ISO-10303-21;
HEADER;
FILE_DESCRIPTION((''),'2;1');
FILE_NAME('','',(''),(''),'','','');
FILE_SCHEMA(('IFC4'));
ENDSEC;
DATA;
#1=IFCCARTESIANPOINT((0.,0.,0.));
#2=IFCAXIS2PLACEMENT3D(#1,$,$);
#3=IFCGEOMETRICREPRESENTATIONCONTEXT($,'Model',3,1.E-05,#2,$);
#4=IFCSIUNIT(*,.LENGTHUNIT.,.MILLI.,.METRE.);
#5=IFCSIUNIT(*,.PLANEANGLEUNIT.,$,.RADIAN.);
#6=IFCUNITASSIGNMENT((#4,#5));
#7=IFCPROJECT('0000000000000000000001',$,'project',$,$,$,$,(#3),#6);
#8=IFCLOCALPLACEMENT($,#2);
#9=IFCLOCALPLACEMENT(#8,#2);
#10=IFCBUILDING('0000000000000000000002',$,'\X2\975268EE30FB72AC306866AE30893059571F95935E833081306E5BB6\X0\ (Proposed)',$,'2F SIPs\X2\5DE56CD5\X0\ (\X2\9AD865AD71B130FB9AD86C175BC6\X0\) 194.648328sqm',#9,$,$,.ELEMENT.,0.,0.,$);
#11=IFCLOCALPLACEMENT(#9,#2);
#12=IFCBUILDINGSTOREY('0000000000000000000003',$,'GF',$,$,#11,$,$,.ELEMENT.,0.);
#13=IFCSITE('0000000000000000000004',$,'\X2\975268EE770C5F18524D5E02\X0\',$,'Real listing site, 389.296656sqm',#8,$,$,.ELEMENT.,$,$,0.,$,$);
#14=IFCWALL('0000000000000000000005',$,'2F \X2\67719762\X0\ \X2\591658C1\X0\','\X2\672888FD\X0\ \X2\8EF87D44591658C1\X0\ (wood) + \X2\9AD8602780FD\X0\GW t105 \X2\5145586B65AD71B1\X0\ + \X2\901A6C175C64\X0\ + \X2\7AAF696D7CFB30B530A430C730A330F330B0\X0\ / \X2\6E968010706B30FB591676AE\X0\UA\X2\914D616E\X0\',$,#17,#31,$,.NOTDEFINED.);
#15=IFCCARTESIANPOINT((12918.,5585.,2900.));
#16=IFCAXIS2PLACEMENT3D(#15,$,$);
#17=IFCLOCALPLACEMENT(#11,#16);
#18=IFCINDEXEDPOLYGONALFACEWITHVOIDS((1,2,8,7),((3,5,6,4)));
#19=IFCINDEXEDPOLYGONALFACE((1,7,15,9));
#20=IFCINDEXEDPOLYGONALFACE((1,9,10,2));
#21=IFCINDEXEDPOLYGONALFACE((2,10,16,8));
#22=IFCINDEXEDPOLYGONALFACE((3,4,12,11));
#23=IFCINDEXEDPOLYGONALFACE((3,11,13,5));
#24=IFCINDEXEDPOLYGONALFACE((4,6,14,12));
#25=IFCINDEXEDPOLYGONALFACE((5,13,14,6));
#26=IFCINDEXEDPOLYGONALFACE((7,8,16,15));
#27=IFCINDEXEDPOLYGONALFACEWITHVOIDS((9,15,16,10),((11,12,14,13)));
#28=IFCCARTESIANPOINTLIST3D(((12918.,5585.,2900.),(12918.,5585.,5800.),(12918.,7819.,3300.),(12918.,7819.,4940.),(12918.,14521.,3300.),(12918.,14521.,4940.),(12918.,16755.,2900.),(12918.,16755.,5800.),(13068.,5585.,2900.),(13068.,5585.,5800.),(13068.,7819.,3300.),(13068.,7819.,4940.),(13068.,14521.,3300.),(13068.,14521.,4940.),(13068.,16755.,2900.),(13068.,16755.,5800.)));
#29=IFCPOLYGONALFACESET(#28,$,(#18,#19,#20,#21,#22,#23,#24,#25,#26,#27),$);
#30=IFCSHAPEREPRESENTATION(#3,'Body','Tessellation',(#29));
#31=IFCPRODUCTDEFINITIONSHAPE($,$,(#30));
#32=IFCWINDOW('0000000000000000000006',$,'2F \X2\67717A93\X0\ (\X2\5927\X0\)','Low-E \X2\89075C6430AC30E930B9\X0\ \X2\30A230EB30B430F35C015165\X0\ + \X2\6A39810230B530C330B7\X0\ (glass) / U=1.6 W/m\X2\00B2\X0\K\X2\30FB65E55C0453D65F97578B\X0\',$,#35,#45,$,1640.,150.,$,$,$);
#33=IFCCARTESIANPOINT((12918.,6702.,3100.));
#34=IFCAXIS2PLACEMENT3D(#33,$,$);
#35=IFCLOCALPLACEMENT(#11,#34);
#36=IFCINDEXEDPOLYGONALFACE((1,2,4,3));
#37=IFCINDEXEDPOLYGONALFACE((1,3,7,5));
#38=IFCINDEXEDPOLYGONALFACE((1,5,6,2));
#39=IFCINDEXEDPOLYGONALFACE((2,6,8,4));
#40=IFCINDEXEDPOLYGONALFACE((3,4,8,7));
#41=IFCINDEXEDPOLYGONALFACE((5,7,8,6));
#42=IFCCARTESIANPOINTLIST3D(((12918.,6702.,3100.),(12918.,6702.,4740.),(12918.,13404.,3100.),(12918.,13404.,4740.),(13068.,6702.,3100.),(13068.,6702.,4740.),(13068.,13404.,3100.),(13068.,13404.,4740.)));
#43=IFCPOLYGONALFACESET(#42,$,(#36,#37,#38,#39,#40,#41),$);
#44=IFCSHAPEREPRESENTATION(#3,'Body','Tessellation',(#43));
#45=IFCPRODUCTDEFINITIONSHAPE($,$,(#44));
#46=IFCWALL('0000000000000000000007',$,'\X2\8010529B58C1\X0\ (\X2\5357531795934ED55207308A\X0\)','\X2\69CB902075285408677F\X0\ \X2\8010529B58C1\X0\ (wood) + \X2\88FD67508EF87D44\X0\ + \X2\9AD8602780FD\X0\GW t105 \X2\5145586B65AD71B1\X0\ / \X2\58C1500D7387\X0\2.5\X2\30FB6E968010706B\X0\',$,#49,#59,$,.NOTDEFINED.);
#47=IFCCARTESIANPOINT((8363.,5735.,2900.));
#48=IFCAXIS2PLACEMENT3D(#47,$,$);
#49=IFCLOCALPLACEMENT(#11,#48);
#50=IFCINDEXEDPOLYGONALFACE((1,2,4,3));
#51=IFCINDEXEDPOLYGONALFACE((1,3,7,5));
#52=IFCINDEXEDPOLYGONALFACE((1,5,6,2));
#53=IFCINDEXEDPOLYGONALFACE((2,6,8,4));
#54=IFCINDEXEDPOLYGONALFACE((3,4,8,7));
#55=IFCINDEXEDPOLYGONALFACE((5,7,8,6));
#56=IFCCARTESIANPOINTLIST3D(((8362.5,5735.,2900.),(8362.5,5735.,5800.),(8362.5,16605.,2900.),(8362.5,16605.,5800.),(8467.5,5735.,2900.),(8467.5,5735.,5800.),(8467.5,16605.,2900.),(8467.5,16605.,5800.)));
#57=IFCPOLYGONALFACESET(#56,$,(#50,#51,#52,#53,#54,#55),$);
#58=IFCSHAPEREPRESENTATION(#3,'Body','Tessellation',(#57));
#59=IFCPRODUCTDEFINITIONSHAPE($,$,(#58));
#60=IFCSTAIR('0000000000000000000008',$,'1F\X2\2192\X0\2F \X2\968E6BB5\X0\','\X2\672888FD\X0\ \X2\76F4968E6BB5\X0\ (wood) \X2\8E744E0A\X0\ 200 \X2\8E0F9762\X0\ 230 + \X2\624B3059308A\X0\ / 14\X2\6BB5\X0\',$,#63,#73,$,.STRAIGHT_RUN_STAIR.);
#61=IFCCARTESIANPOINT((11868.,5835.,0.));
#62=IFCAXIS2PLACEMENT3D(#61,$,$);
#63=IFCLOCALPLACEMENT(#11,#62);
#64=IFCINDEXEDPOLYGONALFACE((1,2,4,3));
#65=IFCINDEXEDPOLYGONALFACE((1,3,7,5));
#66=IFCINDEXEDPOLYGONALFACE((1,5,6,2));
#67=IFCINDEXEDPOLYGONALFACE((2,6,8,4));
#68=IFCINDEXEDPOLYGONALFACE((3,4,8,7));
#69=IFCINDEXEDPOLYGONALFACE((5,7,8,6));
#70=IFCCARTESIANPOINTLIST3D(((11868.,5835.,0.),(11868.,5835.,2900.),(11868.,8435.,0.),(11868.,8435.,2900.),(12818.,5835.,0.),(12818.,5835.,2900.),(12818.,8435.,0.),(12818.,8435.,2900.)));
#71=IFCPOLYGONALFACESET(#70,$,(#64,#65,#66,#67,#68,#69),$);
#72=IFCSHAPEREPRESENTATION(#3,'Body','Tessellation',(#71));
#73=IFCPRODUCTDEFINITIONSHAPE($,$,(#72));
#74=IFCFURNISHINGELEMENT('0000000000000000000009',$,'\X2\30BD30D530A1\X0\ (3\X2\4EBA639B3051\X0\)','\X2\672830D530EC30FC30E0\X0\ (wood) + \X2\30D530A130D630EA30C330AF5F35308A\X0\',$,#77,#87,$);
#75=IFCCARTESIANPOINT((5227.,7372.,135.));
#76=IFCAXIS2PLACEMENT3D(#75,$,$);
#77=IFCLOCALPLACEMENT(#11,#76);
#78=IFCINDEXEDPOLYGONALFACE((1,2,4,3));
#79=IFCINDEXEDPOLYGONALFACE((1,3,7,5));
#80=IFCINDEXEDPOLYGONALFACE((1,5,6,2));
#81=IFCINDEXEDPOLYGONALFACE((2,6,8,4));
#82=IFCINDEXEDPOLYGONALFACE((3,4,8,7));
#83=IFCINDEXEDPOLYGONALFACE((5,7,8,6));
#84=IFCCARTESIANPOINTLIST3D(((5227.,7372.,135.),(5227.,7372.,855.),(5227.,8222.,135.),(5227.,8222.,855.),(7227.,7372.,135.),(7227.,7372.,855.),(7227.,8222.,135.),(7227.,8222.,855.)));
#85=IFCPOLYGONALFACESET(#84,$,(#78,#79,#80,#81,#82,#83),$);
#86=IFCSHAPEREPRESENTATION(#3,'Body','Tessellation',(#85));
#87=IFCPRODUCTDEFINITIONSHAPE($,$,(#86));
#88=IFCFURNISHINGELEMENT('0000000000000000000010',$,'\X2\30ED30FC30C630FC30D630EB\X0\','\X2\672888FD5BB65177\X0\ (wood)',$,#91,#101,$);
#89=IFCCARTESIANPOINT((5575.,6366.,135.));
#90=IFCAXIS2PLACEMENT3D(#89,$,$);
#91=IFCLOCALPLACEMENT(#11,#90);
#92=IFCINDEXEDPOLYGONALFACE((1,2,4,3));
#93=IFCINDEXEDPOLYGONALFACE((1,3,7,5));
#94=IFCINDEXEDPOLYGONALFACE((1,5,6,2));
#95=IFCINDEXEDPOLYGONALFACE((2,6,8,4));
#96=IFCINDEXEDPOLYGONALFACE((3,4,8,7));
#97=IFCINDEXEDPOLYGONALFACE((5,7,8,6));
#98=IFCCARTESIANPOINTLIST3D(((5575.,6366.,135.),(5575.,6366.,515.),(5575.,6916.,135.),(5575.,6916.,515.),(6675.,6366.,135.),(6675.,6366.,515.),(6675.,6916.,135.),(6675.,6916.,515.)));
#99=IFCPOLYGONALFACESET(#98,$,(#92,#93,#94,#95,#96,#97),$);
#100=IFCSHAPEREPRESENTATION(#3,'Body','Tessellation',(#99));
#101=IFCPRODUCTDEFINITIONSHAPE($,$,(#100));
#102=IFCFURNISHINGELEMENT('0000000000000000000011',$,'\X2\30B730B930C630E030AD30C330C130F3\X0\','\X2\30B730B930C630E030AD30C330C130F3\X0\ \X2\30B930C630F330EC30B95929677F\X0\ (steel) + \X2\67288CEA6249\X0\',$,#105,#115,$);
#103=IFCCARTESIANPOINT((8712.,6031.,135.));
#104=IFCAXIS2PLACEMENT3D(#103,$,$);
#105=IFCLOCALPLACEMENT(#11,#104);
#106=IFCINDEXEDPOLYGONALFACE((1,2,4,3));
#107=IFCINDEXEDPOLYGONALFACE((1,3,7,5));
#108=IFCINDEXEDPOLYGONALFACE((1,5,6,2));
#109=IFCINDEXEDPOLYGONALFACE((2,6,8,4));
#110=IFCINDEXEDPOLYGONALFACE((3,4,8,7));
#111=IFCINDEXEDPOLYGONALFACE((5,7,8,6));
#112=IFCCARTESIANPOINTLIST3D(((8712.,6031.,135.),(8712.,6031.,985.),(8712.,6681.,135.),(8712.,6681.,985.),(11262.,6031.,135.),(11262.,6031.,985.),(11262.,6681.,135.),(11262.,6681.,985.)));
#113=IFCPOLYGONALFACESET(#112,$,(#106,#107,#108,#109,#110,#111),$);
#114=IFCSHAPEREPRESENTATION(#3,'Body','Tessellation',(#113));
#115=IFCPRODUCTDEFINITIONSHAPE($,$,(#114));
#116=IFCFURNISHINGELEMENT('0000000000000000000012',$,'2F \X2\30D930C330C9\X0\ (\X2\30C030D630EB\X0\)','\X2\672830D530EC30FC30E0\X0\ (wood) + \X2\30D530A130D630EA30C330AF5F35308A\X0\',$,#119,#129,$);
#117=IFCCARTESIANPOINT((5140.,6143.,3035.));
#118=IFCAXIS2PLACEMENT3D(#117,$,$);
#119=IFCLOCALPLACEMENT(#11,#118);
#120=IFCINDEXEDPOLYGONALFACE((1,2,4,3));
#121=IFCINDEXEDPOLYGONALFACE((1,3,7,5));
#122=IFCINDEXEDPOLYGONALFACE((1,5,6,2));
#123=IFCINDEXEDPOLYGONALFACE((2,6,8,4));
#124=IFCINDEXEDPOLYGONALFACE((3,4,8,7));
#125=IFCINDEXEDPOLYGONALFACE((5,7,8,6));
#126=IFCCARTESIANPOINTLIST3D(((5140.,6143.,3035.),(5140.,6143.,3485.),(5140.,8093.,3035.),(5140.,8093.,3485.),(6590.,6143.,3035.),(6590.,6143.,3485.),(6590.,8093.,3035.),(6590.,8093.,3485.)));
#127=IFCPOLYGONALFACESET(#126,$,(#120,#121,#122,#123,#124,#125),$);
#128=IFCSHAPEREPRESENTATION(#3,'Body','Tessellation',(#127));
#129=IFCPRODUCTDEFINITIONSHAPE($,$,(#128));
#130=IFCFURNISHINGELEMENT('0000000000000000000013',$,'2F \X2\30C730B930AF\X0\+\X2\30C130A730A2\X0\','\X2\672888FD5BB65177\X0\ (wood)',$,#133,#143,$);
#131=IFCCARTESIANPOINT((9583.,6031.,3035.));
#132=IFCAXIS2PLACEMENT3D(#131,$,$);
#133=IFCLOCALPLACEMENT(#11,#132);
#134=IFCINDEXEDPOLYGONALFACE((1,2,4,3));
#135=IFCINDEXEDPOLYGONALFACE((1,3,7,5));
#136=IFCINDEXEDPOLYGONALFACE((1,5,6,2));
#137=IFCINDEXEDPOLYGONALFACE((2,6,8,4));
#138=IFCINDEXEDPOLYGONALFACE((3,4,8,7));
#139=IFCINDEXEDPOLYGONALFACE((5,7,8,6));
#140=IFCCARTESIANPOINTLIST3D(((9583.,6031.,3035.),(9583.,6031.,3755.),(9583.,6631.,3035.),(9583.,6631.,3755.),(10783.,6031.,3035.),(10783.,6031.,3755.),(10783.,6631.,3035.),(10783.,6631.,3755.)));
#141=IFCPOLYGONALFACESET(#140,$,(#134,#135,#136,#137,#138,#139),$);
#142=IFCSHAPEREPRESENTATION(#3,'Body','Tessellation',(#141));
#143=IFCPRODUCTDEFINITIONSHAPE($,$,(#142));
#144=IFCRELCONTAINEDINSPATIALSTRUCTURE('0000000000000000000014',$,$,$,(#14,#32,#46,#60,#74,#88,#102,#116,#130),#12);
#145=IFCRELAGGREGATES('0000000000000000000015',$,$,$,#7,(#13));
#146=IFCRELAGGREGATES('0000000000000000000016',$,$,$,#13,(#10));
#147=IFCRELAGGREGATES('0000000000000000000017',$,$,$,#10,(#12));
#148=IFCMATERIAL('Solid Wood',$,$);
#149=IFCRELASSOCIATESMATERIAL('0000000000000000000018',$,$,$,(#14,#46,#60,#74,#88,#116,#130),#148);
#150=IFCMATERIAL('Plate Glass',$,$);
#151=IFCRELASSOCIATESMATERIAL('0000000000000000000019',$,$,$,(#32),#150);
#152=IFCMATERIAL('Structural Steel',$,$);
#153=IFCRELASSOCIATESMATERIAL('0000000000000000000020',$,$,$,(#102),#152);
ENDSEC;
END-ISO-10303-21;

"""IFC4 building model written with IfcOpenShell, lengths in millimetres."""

from ifc_helpers import new_model, si_unit, frame, frame_2d, origin, place, context, project, spatial, rectangle, extrude, material, element, fill, save


model = new_model("IFC4")

# Units and contexts
model_context = context("Model", 3, precision=1e-05, world=origin())
ifc_project = project(units=[si_unit("LENGTHUNIT", "METRE", prefix="MILLI"), si_unit("PLANEANGLEUNIT", "RADIAN")], contexts=[model_context])

# Site, building, storey
site_placement = place(None, origin())
site = spatial("IfcSite", under=ifc_project, at=site_placement, Name="青森県弘前市", ObjectType="Real listing site, 389.296656sqm", CompositionType="ELEMENT", RefElevation=0.0)
building_placement = place(site_placement, origin())
building = spatial("IfcBuilding", under=site, at=building_placement, Name="青森・犬と暮らす土間広めの家 (Proposed)", ObjectType="2F SIPs工法 (高断熱・高気密) 194.648328sqm", CompositionType="ELEMENT", ElevationOfRefHeight=0.0, ElevationOfTerrain=0.0)
storey_placement = place(building_placement, origin())
storey = spatial("IfcBuildingStorey", under=building, at=storey_placement, Name="GF", CompositionType="ELEMENT", Elevation=0.0)

# Shared definitions
ifc_material_1 = material(Name="Solid Wood")
ifc_material_2 = material(Name="Plate Glass")

# Wall, opening, window
wall_1_placement = place(storey_placement, frame((12918.0, 5585.0, 2900.0)))
wall_1 = element("IfcWall", 1, at=wall_1_placement, inside=storey, material=ifc_material_1, Name="2F 東面 外壁", Description="木製 軸組外壁 (wood) + 高性能GW t105 充填断熱 + 通気層 + 窯業系サイディング / 準耐火・外皮UA配慮", PredefinedType="NOTDEFINED", context=model_context, shape_type="SweptSolid", body=[
    extrude(rectangle(XDim=150.0, YDim=11170.0, at=frame_2d((75.0, 5585.0))), frame((12918.0, 5585.0, 2900.0)), (0.0, 0.0, 1.0), 2900.0),
])
opening_1_placement = place(storey_placement, frame((12918.0, 6702.0, 3100.0)))
opening_1 = element("IfcOpeningElement", 2, at=opening_1_placement, cuts=wall_1, PredefinedType="NOTDEFINED", context=model_context, shape_type="SweptSolid", body=[
    extrude(rectangle(XDim=150.0, YDim=6702.0, at=frame_2d((75.0, 3351.0))), frame((12918.0, 6702.0, 3100.0)), (0.0, 0.0, 1.0), 1640.0),
])
window_1_placement = place(storey_placement, frame((12918.0, 6702.0, 3100.0)))
window_1 = element("IfcWindow", 3, at=window_1_placement, inside=storey, material=ifc_material_2, Name="2F 東窓 (大)", Description="Low-E 複層ガラス アルゴン封入 + 樹脂サッシ (glass) / U=1.6 W/m²K・日射取得型", OverallHeight=1640.0, OverallWidth=150.0, context=model_context, shape_type="SweptSolid", body=[
    extrude(rectangle(XDim=150.0, YDim=6702.0, at=frame_2d((75.0, 3351.0))), frame((12918.0, 6702.0, 3100.0)), (0.0, 0.0, 1.0), 1640.0),
])
fill(opening_1, window_1)

# Wall
wall_2_placement = place(storey_placement, frame((8363.0, 5735.0, 2900.0)))
element("IfcWall", 4, at=wall_2_placement, inside=storey, material=ifc_material_1, Name="耐力壁 (南北間仕切り)", Description="構造用合板 耐力壁 (wood) + 製材軸組 + 高性能GW t105 充填断熱 / 壁倍率2.5・準耐火", PredefinedType="NOTDEFINED", context=model_context, shape_type="SweptSolid", body=[
    extrude(rectangle(XDim=105.0, YDim=10870.0, at=frame_2d((52.0, 5435.0))), frame((8363.0, 5735.0, 2900.0)), (0.0, 0.0, 1.0), 2900.0),
])

# Stair
stair_placement = place(storey_placement, frame((11868.0, 5835.0, 0.0)))
element("IfcStair", 5, at=stair_placement, inside=storey, material=ifc_material_1, Name="1F→2F 階段", Description="木製 直階段 (wood) 蹴上 200 踏面 230 + 手すり / 14段", PredefinedType="STRAIGHT_RUN_STAIR", context=model_context, shape_type="SweptSolid", body=[
    extrude(rectangle(XDim=950.0, YDim=2600.0, at=frame_2d((475.0, 1300.0))), frame((11868.0, 5835.0, 0.0)), (0.0, 0.0, 1.0), 2900.0),
])

# Furnishing elements
furnishing_1_placement = place(storey_placement, frame((5227.0, 7372.0, 135.0)))
element("IfcFurnishingElement", 6, at=furnishing_1_placement, inside=storey, material=ifc_material_1, Name="ソファ (3人掛け)", Description="木フレーム (wood) + ファブリック張り", context=model_context, shape_type="SweptSolid", body=[
    extrude(rectangle(XDim=2000.0, YDim=850.0, at=frame_2d((1000.0, 425.0))), frame((5227.0, 7372.0, 135.0)), (0.0, 0.0, 1.0), 720.0),
])
furnishing_2_placement = place(storey_placement, frame((5575.0, 6366.0, 135.0)))
element("IfcFurnishingElement", 7, at=furnishing_2_placement, inside=storey, material=ifc_material_1, Name="ローテーブル", Description="木製家具 (wood)", context=model_context, shape_type="SweptSolid", body=[
    extrude(rectangle(XDim=1100.0, YDim=550.0, at=frame_2d((550.0, 275.0))), frame((5575.0, 6366.0, 135.0)), (0.0, 0.0, 1.0), 380.0),
])
ifc_material_3 = material(Name="Structural Steel")
furnishing_3_placement = place(storey_placement, frame((8712.0, 6031.0, 135.0)))
element("IfcFurnishingElement", 8, at=furnishing_3_placement, inside=storey, material=ifc_material_3, Name="システムキッチン", Description="システムキッチン ステンレス天板 (steel) + 木質扉", context=model_context, shape_type="SweptSolid", body=[
    extrude(rectangle(XDim=2550.0, YDim=650.0, at=frame_2d((1275.0, 325.0))), frame((8712.0, 6031.0, 135.0)), (0.0, 0.0, 1.0), 850.0),
])
furnishing_4_placement = place(storey_placement, frame((5140.0, 6143.0, 3035.0)))
element("IfcFurnishingElement", 9, at=furnishing_4_placement, inside=storey, material=ifc_material_1, Name="2F ベッド (ダブル)", Description="木フレーム (wood) + ファブリック張り", context=model_context, shape_type="SweptSolid", body=[
    extrude(rectangle(XDim=1450.0, YDim=1950.0, at=frame_2d((725.0, 975.0))), frame((5140.0, 6143.0, 3035.0)), (0.0, 0.0, 1.0), 450.0),
])
furnishing_5_placement = place(storey_placement, frame((9583.0, 6031.0, 3035.0)))
element("IfcFurnishingElement", 10, at=furnishing_5_placement, inside=storey, material=ifc_material_1, Name="2F デスク+チェア", Description="木製家具 (wood)", context=model_context, shape_type="SweptSolid", body=[
    extrude(rectangle(XDim=1200.0, YDim=600.0, at=frame_2d((600.0, 300.0))), frame((9583.0, 6031.0, 3035.0)), (0.0, 0.0, 1.0), 720.0),
])

save(model, "model.ifc")
